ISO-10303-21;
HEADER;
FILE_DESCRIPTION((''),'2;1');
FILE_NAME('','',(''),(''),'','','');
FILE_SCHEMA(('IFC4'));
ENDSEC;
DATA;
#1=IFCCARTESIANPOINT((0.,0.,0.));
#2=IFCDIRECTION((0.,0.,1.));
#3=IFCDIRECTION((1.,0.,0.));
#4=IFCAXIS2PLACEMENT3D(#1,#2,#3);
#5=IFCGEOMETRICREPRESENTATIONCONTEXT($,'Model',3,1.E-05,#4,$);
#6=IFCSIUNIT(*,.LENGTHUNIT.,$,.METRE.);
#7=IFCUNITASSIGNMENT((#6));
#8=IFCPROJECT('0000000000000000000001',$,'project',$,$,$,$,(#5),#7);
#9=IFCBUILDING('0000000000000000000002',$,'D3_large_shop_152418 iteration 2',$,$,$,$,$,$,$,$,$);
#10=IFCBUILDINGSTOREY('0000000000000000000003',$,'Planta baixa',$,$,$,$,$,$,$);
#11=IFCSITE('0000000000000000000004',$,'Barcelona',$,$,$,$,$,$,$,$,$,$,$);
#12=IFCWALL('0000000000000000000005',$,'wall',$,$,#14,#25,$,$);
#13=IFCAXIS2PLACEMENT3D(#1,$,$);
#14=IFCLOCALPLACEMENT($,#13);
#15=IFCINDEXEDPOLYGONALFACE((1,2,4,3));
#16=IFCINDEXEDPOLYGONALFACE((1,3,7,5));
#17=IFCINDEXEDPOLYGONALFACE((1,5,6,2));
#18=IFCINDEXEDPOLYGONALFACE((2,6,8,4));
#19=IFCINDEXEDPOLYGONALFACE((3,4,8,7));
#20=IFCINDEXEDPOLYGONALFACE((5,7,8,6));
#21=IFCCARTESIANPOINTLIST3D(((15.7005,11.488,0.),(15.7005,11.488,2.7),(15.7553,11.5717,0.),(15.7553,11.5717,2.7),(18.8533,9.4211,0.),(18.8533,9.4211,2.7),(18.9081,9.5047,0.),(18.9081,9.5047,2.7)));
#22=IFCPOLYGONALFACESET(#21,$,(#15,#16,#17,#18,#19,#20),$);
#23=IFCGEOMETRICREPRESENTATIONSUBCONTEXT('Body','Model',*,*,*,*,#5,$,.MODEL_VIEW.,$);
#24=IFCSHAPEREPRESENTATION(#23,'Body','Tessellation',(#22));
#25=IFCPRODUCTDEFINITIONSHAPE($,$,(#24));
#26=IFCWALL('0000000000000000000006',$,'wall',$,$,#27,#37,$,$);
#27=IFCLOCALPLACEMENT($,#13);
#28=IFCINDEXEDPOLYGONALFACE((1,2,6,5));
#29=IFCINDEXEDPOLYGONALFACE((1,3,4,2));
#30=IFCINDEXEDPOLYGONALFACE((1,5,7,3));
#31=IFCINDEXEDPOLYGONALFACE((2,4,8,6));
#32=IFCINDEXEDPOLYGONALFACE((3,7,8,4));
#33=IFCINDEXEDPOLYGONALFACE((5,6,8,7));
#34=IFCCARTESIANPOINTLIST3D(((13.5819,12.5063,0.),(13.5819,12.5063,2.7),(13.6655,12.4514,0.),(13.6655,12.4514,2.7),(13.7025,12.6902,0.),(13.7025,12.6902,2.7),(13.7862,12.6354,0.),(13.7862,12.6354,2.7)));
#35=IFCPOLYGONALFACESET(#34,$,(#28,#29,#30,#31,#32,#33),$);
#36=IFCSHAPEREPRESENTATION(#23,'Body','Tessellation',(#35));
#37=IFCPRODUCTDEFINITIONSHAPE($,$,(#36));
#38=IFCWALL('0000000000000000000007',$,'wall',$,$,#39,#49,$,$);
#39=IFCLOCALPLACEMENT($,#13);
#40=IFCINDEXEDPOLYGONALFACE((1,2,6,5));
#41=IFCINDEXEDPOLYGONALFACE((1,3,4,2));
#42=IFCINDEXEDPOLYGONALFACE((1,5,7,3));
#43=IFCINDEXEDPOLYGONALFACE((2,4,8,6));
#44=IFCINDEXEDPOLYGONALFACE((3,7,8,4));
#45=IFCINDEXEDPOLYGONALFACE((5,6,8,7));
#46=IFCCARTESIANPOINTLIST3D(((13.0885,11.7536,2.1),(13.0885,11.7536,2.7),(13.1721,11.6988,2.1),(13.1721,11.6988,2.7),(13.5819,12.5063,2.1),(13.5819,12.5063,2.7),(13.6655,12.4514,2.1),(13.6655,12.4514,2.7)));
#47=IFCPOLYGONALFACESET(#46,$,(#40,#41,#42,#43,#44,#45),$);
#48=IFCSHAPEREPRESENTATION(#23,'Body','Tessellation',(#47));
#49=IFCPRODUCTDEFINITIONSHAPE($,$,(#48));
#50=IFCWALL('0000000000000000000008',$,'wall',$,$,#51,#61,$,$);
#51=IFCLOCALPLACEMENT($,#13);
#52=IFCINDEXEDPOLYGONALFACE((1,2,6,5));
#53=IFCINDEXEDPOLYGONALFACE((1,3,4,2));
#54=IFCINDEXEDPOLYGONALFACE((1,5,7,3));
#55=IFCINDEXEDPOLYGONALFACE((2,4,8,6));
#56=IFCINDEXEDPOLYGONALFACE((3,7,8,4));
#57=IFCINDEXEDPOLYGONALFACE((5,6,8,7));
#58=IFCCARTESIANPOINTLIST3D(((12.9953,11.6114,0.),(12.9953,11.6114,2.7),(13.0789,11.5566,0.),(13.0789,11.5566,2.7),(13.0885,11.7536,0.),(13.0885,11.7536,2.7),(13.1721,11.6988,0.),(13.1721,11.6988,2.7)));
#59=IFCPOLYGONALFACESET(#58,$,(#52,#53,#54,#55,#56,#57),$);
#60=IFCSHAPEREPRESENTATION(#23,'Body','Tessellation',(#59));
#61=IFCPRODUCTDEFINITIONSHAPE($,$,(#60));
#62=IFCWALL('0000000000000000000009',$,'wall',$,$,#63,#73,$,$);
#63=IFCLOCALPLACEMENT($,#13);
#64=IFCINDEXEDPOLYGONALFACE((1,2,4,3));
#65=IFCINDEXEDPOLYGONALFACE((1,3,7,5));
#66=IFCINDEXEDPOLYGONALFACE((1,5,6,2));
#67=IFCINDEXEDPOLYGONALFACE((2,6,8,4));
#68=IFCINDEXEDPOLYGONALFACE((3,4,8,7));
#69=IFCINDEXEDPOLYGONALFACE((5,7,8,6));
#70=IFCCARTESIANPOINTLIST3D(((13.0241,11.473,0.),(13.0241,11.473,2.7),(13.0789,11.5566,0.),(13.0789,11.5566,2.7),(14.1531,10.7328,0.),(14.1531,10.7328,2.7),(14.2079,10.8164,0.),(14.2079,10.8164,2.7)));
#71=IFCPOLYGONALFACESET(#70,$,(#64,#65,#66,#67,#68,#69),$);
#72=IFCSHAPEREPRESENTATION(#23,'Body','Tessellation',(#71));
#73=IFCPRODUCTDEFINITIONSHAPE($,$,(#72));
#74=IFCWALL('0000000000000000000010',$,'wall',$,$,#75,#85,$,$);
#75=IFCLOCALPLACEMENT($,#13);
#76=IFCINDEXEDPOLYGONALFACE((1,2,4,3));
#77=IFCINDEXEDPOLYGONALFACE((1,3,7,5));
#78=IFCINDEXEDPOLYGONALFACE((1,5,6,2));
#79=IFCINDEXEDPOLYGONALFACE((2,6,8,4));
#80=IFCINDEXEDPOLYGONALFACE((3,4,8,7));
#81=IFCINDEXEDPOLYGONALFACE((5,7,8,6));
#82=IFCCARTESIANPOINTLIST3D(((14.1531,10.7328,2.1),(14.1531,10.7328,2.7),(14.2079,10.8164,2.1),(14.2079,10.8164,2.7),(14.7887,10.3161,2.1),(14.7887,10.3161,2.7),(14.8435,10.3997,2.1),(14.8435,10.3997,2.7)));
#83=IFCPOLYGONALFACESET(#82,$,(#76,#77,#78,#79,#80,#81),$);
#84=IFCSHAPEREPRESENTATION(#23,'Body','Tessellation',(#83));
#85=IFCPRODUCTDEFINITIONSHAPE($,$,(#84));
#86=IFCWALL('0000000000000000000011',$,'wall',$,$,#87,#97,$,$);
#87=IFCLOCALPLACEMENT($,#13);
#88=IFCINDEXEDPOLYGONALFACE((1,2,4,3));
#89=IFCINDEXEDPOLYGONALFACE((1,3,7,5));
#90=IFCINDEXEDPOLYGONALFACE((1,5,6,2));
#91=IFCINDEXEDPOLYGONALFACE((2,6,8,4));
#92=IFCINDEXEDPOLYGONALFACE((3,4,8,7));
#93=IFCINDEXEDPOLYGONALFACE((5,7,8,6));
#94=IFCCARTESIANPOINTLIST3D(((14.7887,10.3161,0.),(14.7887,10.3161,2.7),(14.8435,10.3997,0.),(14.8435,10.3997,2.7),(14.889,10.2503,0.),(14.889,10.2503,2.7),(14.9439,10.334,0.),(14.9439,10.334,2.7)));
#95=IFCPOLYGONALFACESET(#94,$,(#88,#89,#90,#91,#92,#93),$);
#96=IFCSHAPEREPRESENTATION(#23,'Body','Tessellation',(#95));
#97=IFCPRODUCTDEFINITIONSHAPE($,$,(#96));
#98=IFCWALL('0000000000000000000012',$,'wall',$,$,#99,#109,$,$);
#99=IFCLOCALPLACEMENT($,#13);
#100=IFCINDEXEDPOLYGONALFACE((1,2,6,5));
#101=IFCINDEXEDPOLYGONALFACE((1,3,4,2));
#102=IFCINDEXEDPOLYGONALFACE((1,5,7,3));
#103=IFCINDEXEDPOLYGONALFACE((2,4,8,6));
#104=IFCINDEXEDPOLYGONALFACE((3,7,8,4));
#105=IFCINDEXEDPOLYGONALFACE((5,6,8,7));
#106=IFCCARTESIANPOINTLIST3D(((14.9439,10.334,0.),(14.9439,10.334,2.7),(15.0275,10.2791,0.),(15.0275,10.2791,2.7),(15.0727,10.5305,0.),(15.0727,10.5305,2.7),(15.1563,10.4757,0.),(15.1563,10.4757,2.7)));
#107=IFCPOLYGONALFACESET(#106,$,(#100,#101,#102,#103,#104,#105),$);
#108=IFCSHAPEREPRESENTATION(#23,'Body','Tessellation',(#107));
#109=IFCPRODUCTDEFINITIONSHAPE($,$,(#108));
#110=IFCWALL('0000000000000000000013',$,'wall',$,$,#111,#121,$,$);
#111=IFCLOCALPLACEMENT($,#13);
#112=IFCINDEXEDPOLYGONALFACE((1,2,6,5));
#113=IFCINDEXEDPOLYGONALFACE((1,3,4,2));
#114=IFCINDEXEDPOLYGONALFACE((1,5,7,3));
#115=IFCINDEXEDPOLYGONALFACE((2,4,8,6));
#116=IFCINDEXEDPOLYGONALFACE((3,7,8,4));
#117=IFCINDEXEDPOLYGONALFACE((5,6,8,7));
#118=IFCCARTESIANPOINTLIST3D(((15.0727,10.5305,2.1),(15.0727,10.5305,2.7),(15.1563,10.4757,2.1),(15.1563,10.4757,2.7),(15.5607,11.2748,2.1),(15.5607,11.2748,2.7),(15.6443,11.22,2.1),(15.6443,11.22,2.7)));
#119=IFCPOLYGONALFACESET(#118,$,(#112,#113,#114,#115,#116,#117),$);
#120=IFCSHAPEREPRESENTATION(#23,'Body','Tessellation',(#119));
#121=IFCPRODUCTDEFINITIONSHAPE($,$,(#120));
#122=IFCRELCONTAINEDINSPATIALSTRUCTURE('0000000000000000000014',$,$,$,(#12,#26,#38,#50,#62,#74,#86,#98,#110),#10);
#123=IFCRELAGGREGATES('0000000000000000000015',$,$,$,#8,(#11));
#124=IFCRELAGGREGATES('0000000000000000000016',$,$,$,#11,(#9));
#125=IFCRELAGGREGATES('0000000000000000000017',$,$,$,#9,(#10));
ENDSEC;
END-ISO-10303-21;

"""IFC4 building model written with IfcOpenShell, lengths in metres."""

from ifc_helpers import new_model, si_unit, frame, origin, origin_with_axes, place, context, subcontext, project, spatial, polyline, outline, extrude, element, save


model = new_model("IFC4")

# Units and contexts
model_context = context("Model", 3, precision=1e-05, world=origin_with_axes())
body_context = subcontext(model_context, "Body", "Model", "MODEL_VIEW")
ifc_project = project(units=[si_unit("LENGTHUNIT", "METRE")], contexts=[model_context])

# Site, building, storey
site = spatial("IfcSite", under=ifc_project, Name="Barcelona")
building = spatial("IfcBuilding", under=site, Name="D3_large_shop_152418 iteration 2")
storey = spatial("IfcBuildingStorey", under=building, Name="Planta baixa")

# Walls
wall_1_placement = place(None, origin_with_axes())
element("IfcWall", 1, at=wall_1_placement, inside=storey, Name="wall", context=body_context, shape_type="SweptSolid", body=[
    extrude(outline(polyline([(15.7553, 11.5717), (18.9081, 9.5047), (18.8533, 9.4211), (15.7005, 11.488), (15.7553, 11.5717)])), origin(), (0.0, 0.0, 1.0), 2.7),
])
wall_2_placement = place(None, origin_with_axes())
element("IfcWall", 2, at=wall_2_placement, inside=storey, Name="wall", context=body_context, shape_type="SweptSolid", body=[
    extrude(outline(polyline([(13.7862, 12.6354), (13.6655, 12.4514), (13.5819, 12.5063), (13.7025, 12.6902), (13.7862, 12.6354)])), origin(), (0.0, 0.0, 1.0), 2.7),
])
wall_3_placement = place(None, origin_with_axes())
element("IfcWall", 3, at=wall_3_placement, inside=storey, Name="wall", context=body_context, shape_type="SweptSolid", body=[
    extrude(outline(polyline([(13.6655, 12.4514), (13.1721, 11.6988), (13.0885, 11.7536), (13.5819, 12.5063), (13.6655, 12.4514)])), frame((0.0, 0.0, 2.1)), (0.0, 0.0, 1.0), 0.6),
])
wall_4_placement = place(None, origin_with_axes())
element("IfcWall", 4, at=wall_4_placement, inside=storey, Name="wall", context=body_context, shape_type="SweptSolid", body=[
    extrude(outline(polyline([(13.1721, 11.6988), (13.0789, 11.5566), (12.9953, 11.6114), (13.0885, 11.7536), (13.1721, 11.6988)])), origin(), (0.0, 0.0, 1.0), 2.7),
])
wall_5_placement = place(None, origin_with_axes())
element("IfcWall", 5, at=wall_5_placement, inside=storey, Name="wall", context=body_context, shape_type="SweptSolid", body=[
    extrude(outline(polyline([(13.0789, 11.5566), (14.2079, 10.8164), (14.1531, 10.7328), (13.0241, 11.473), (13.0789, 11.5566)])), origin(), (0.0, 0.0, 1.0), 2.7),
])
wall_6_placement = place(None, origin_with_axes())
element("IfcWall", 6, at=wall_6_placement, inside=storey, Name="wall", context=body_context, shape_type="SweptSolid", body=[
    extrude(outline(polyline([(14.2079, 10.8164), (14.8435, 10.3997), (14.7887, 10.3161), (14.1531, 10.7328), (14.2079, 10.8164)])), frame((0.0, 0.0, 2.1)), (0.0, 0.0, 1.0), 0.6),
])
wall_7_placement = place(None, origin_with_axes())
element("IfcWall", 7, at=wall_7_placement, inside=storey, Name="wall", context=body_context, shape_type="SweptSolid", body=[
    extrude(outline(polyline([(14.8435, 10.3997), (14.9439, 10.334), (14.889, 10.2503), (14.7887, 10.3161), (14.8435, 10.3997)])), origin(), (0.0, 0.0, 1.0), 2.7),
])
wall_8_placement = place(None, origin_with_axes())
element("IfcWall", 8, at=wall_8_placement, inside=storey, Name="wall", context=body_context, shape_type="SweptSolid", body=[
    extrude(outline(polyline([(14.9439, 10.334), (15.0727, 10.5305), (15.1563, 10.4757), (15.0275, 10.2791), (14.9439, 10.334)])), origin(), (0.0, 0.0, 1.0), 2.7),
])
wall_9_placement = place(None, origin_with_axes())
element("IfcWall", 9, at=wall_9_placement, inside=storey, Name="wall", context=body_context, shape_type="SweptSolid", body=[
    extrude(outline(polyline([(15.0727, 10.5305), (15.5607, 11.2748), (15.6443, 11.22), (15.1563, 10.4757), (15.0727, 10.5305)])), frame((0.0, 0.0, 2.1)), (0.0, 0.0, 1.0), 0.6),
])

save(model, "model.ifc")
